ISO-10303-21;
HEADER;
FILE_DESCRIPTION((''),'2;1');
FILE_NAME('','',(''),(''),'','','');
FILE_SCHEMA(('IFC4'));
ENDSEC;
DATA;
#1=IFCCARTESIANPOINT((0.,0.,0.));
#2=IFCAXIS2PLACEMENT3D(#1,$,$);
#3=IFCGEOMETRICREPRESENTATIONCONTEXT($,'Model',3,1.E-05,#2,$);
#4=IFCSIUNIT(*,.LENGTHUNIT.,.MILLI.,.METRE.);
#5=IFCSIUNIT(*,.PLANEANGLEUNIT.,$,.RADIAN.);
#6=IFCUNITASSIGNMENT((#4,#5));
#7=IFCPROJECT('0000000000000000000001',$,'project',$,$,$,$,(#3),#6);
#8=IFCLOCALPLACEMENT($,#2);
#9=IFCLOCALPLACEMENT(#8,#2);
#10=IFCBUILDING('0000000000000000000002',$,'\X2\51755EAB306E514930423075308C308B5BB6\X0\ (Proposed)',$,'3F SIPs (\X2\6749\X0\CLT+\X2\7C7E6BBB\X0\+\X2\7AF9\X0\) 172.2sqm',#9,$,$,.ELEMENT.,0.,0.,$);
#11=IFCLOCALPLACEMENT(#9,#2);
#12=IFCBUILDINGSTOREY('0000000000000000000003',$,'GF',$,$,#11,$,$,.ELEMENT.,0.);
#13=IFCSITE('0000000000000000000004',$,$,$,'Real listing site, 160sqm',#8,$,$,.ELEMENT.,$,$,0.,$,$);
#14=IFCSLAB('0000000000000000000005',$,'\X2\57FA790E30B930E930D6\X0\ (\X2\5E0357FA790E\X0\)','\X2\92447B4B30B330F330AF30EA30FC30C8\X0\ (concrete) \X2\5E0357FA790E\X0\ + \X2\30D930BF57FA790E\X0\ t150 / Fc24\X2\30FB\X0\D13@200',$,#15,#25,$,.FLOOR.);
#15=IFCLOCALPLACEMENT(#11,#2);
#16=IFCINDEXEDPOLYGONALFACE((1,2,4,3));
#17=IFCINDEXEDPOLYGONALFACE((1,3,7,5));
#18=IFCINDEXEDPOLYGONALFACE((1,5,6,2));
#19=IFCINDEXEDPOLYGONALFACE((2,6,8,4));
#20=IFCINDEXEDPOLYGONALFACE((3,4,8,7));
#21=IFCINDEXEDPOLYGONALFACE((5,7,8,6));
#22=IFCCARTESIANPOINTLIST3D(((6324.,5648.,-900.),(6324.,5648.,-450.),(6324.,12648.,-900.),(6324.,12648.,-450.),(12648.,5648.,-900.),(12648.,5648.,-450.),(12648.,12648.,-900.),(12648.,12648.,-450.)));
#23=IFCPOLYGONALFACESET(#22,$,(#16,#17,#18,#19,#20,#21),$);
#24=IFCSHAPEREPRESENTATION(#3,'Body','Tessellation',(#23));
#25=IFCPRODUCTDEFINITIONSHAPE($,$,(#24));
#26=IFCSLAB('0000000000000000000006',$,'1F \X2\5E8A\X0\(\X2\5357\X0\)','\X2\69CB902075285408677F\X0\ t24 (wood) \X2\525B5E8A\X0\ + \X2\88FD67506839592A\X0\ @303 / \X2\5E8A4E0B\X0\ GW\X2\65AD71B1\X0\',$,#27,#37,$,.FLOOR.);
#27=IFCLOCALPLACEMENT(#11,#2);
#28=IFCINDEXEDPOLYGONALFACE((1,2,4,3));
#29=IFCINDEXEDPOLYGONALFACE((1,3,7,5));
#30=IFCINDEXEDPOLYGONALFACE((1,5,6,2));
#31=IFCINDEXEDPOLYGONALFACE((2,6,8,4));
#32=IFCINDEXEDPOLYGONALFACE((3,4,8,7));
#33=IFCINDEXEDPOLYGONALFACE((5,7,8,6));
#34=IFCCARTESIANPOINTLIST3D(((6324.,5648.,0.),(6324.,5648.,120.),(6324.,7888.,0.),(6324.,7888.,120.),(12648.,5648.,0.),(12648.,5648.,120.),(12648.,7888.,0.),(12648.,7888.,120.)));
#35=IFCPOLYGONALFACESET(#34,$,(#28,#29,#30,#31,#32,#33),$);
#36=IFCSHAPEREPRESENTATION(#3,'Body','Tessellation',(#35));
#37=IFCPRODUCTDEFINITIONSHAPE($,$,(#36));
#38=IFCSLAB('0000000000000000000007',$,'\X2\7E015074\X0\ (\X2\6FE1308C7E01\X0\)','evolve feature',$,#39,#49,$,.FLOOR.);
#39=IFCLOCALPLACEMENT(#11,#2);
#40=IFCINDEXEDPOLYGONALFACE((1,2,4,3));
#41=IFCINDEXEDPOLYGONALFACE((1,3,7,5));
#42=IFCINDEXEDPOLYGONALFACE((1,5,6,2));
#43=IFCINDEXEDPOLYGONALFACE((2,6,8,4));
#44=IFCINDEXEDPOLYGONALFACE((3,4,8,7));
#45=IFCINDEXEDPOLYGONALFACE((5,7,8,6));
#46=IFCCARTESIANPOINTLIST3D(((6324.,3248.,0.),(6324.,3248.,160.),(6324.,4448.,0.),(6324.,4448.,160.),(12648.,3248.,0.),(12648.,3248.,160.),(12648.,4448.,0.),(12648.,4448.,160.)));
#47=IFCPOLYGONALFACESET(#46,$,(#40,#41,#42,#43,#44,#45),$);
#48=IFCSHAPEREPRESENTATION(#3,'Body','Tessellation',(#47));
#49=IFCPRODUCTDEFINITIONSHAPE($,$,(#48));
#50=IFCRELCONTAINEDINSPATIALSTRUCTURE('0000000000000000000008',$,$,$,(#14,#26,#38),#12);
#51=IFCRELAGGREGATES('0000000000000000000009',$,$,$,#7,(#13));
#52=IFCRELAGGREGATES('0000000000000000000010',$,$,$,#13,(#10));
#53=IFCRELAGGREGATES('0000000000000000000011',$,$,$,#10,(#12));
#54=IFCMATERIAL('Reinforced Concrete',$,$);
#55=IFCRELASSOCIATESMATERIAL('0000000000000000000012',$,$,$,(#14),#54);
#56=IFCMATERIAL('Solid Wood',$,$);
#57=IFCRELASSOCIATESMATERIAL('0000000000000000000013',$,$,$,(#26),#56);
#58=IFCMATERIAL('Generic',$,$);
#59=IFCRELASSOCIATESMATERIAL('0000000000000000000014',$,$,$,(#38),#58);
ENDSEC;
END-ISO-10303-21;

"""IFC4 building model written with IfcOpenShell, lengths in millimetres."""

from ifc_helpers import new_model, si_unit, frame, frame_2d, origin, place, context, project, spatial, rectangle, extrude, material, element, save


model = new_model("IFC4")

# Units and contexts
model_context = context("Model", 3, precision=1e-05, world=origin())
ifc_project = project(units=[si_unit("LENGTHUNIT", "METRE", prefix="MILLI"), si_unit("PLANEANGLEUNIT", "RADIAN")], contexts=[model_context])

# Site, building, storey
site_placement = place(None, origin())
site = spatial("IfcSite", under=ifc_project, at=site_placement, ObjectType="Real listing site, 160sqm", CompositionType="ELEMENT", RefElevation=0.0)
building_placement = place(site_placement, origin())
building = spatial("IfcBuilding", under=site, at=building_placement, Name="兵庫の光あふれる家 (Proposed)", ObjectType="3F SIPs (杉CLT+籾殻+竹) 172.2sqm", CompositionType="ELEMENT", ElevationOfRefHeight=0.0, ElevationOfTerrain=0.0)
storey_placement = place(building_placement, origin())
storey = spatial("IfcBuildingStorey", under=building, at=storey_placement, Name="GF", CompositionType="ELEMENT", Elevation=0.0)

# Slabs
ifc_material_1 = material(Name="Reinforced Concrete")
slab_1_placement = place(storey_placement, frame((3162.0, 2824.0, -450.0)))
element("IfcSlab", 1, at=slab_1_placement, inside=storey, material=ifc_material_1, Name="基礎スラブ (布基礎)", Description="鉄筋コンクリート (concrete) 布基礎 + ベタ基礎 t150 / Fc24・D13@200", PredefinedType="FLOOR", context=model_context, shape_type="SweptSolid", body=[
    extrude(rectangle(XDim=6324.0, YDim=7000.0, at=frame_2d((3162.0, 3500.0))), frame((3162.0, 2824.0, -450.0)), (0.0, 0.0, 1.0), 450.0),
])
ifc_material_2 = material(Name="Solid Wood")
slab_2_placement = place(storey_placement, frame((3162.0, 2824.0, 0.0)))
element("IfcSlab", 2, at=slab_2_placement, inside=storey, material=ifc_material_2, Name="1F 床(南)", Description="構造用合板 t24 (wood) 剛床 + 製材根太 @303 / 床下 GW断熱", PredefinedType="FLOOR", context=model_context, shape_type="SweptSolid", body=[
    extrude(rectangle(XDim=6324.0, YDim=2240.0, at=frame_2d((3162.0, 1120.0))), frame((3162.0, 2824.0, 0.0)), (0.0, 0.0, 1.0), 120.0),
])
ifc_material_3 = material(Name="Generic")
slab_3_placement = place(storey_placement, frame((3162.0, 1624.0, 0.0)))
element("IfcSlab", 3, at=slab_3_placement, inside=storey, material=ifc_material_3, Name="縁側 (濡れ縁)", Description="evolve feature", PredefinedType="FLOOR", context=model_context, shape_type="SweptSolid", body=[
    extrude(rectangle(XDim=6324.0, YDim=1200.0, at=frame_2d((3162.0, 600.0))), frame((3162.0, 1624.0, 0.0)), (0.0, 0.0, 1.0), 160.0),
])

save(model, "model.ifc")
